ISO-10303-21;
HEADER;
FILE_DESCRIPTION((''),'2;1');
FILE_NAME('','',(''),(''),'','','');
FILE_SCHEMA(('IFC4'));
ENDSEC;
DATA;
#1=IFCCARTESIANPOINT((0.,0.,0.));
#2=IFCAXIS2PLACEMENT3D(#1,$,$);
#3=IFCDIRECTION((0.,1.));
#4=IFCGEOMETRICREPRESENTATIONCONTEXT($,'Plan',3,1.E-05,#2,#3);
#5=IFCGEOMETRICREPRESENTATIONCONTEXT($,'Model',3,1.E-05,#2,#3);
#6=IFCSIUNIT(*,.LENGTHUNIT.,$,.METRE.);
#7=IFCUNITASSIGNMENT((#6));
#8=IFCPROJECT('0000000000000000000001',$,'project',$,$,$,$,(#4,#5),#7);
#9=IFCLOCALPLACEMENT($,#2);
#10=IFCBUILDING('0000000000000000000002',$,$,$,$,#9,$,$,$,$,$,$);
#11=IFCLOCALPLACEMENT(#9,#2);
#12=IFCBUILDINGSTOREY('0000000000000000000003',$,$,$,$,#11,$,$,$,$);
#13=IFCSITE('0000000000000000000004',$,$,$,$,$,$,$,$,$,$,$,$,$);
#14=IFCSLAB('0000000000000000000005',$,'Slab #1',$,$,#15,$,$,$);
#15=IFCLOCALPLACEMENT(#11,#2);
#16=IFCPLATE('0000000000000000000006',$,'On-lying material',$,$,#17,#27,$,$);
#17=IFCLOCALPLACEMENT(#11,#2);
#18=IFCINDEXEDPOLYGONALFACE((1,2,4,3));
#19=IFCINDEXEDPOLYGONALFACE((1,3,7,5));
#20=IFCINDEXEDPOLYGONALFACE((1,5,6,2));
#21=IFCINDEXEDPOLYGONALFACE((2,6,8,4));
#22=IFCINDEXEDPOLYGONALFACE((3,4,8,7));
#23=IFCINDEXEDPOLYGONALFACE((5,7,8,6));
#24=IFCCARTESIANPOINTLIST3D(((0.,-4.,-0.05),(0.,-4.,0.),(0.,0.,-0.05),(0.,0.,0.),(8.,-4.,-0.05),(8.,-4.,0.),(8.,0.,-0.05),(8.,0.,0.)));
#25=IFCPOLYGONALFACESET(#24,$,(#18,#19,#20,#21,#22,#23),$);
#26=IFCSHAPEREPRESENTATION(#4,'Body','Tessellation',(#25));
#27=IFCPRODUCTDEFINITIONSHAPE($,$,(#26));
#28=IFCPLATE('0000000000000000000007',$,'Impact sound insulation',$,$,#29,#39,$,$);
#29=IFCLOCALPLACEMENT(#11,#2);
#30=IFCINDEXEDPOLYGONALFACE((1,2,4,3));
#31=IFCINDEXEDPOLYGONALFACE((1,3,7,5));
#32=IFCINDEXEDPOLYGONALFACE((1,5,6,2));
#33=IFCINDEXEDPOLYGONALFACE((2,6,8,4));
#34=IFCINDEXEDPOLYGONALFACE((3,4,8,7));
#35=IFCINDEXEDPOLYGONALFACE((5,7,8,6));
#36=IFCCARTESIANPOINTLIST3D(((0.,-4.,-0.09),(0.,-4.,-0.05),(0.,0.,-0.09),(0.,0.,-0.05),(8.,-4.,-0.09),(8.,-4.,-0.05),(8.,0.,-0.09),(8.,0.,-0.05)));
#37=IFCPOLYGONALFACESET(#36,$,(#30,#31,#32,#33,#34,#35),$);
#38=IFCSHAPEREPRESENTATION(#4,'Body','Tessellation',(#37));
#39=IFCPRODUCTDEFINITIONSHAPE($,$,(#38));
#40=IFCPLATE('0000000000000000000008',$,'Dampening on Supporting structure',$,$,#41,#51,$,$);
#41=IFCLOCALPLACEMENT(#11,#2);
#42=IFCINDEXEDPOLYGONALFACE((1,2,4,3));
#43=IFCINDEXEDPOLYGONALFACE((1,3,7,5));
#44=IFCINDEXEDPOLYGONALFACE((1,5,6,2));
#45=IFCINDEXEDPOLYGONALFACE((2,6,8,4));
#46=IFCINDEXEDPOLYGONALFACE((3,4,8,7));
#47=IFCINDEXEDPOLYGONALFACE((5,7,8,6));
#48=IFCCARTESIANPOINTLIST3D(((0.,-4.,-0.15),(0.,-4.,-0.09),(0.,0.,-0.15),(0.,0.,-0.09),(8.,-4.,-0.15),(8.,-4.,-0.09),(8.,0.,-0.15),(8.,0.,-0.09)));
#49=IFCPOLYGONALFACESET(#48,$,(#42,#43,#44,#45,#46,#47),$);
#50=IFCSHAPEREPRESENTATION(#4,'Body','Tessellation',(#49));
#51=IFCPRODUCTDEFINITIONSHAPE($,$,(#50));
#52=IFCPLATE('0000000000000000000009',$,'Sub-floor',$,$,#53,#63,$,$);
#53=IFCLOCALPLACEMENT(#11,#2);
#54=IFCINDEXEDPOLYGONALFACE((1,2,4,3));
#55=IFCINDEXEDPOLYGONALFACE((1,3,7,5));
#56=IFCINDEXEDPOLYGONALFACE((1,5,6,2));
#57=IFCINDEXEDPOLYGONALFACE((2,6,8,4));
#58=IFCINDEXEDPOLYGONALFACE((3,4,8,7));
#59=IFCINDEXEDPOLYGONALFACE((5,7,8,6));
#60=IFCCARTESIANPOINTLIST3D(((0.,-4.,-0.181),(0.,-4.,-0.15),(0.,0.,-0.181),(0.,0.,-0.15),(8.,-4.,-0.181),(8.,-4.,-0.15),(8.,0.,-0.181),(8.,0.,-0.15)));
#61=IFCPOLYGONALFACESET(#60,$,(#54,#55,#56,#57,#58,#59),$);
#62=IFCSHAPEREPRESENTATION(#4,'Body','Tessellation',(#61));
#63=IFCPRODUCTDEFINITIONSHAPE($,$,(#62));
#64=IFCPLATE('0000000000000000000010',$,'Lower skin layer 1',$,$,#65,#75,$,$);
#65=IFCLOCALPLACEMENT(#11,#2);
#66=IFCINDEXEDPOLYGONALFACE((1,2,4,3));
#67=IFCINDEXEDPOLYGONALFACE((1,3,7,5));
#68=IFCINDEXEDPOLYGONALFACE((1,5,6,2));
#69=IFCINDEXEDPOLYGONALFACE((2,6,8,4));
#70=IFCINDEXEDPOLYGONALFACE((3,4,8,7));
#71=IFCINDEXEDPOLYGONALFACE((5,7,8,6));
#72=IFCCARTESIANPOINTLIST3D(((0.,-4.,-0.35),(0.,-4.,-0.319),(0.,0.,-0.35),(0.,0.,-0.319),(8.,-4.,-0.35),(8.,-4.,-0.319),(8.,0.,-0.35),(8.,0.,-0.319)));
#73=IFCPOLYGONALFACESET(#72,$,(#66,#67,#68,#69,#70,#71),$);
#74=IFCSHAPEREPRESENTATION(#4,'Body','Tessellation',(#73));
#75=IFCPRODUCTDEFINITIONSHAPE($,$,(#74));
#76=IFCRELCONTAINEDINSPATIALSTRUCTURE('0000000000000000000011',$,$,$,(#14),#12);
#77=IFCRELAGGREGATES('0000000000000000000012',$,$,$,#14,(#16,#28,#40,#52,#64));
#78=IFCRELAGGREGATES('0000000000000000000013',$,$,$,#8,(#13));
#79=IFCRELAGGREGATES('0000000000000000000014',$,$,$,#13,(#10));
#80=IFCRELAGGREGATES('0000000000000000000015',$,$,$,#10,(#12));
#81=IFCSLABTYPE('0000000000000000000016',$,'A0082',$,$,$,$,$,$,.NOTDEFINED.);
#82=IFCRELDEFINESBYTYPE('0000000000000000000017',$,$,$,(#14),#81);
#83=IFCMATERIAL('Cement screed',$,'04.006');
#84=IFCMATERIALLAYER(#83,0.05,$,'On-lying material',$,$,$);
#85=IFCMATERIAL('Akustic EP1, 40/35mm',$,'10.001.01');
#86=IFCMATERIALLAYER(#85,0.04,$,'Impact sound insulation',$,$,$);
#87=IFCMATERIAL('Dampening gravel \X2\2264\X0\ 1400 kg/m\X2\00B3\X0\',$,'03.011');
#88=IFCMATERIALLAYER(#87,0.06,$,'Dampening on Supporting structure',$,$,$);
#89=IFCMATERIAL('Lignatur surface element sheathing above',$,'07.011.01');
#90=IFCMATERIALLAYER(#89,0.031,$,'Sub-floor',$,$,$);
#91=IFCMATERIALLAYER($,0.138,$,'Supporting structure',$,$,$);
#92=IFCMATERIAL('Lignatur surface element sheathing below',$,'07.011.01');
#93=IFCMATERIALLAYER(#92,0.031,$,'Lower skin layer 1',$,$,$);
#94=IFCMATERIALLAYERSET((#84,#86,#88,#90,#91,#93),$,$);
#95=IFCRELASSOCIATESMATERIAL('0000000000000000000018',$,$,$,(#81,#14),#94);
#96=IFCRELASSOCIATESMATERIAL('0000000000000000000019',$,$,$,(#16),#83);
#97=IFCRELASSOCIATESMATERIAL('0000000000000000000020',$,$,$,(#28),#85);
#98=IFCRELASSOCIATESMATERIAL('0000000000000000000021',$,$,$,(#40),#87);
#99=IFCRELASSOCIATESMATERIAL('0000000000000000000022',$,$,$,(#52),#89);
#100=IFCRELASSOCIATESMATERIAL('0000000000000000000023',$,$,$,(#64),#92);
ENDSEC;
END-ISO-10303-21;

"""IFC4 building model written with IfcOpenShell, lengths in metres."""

from ifc_helpers import new_model, si_unit, direction, frame, frame_2d, origin, origin_with_axes, place, context, project, spatial, rectangle, extrude, material, layer, layer_set, type_object, element, aggregate, save


model = new_model("IFC4")

# Units and contexts
plan_context = context("Plan", 3, precision=1e-05, world=origin(), true_north=direction((0.0, 1.0)))
model_context = context("Model", 3, precision=1e-05, world=origin(), true_north=direction((0.0, 1.0)))
ifc_project = project(units=[si_unit("LENGTHUNIT", "METRE")], contexts=[plan_context, model_context])

# Site, building, storey
site = spatial("IfcSite", under=ifc_project)
building_placement = place(None, origin())
building = spatial("IfcBuilding", under=site, at=building_placement)
storey_placement = place(building_placement, origin())
storey = spatial("IfcBuildingStorey", under=building, at=storey_placement)

# Slab, plates
ifc_material_1 = material(Name="Cement screed", Category="04.006")
ifc_layer_1 = layer(ifc_material_1, 0.05, Name="On-lying material")
ifc_material_2 = material(Name="Akustic EP1, 40/35mm", Category="10.001.01")
ifc_layer_2 = layer(ifc_material_2, 0.04, Name="Impact sound insulation")
ifc_material_3 = material(Name="Dampening gravel ≤ 1400 kg/m³", Category="03.011")
ifc_layer_3 = layer(ifc_material_3, 0.06, Name="Dampening on Supporting structure")
ifc_material_4 = material(Name="Lignatur surface element sheathing above", Category="07.011.01")
ifc_layer_4 = layer(ifc_material_4, 0.031, Name="Sub-floor")
ifc_layer_5 = layer(None, 0.138, Name="Supporting structure")
ifc_material_5 = material(Name="Lignatur surface element sheathing below", Category="07.011.01")
ifc_layer_6 = layer(ifc_material_5, 0.031, Name="Lower skin layer 1")
ifc_layer_set = layer_set([ifc_layer_1, ifc_layer_2, ifc_layer_3, ifc_layer_4, ifc_layer_5, ifc_layer_6])
slab_type = type_object("IfcSlabType", Name="A0082", PredefinedType="NOTDEFINED", material=ifc_layer_set)
slab_placement = place(None, frame((0.0, 0.0, 0.0), z_axis=(0.0, 0.0, -1.0), x_axis=(1.0, 0.0, 0.0)))
slab = element("IfcSlab", 1, at=slab_placement, inside=storey, type_object=slab_type, material=ifc_layer_set, Name="Slab #1")
plate_1_placement = place(slab_placement, origin())
plate_1 = element("IfcPlate", 2, at=plate_1_placement, material=ifc_material_1, Name="On-lying material", context=plan_context, shape_type="SweptSolid", body=[
    extrude(rectangle(XDim=8.0, YDim=4.0, at=frame_2d((4.0, 2.0), x_axis=(1.0, 0.0))), origin_with_axes(), (0.0, 0.0, 1.0), 0.05),
])
plate_2_placement = place(slab_placement, origin())
plate_2 = element("IfcPlate", 3, at=plate_2_placement, material=ifc_material_2, Name="Impact sound insulation", context=plan_context, shape_type="SweptSolid", body=[
    extrude(rectangle(XDim=8.0, YDim=4.0, at=frame_2d((4.0, 2.0), x_axis=(1.0, 0.0))), frame((0.0, 0.0, 0.05), z_axis=(0.0, 0.0, 1.0), x_axis=(1.0, 0.0, 0.0)), (0.0, 0.0, 1.0), 0.04),
])
plate_3_placement = place(slab_placement, origin())
plate_3 = element("IfcPlate", 4, at=plate_3_placement, material=ifc_material_3, Name="Dampening on Supporting structure", context=plan_context, shape_type="SweptSolid", body=[
    extrude(rectangle(XDim=8.0, YDim=4.0, at=frame_2d((4.0, 2.0), x_axis=(1.0, 0.0))), frame((0.0, 0.0, 0.09), z_axis=(0.0, 0.0, 1.0), x_axis=(1.0, 0.0, 0.0)), (0.0, 0.0, 1.0), 0.06),
])
plate_4_placement = place(slab_placement, origin())
plate_4 = element("IfcPlate", 5, at=plate_4_placement, material=ifc_material_4, Name="Sub-floor", context=plan_context, shape_type="SweptSolid", body=[
    extrude(rectangle(XDim=8.0, YDim=4.0, at=frame_2d((4.0, 2.0), x_axis=(1.0, 0.0))), frame((0.0, 0.0, 0.15), z_axis=(0.0, 0.0, 1.0), x_axis=(1.0, 0.0, 0.0)), (0.0, 0.0, 1.0), 0.031),
])
plate_5_placement = place(slab_placement, origin())
plate_5 = element("IfcPlate", 6, at=plate_5_placement, material=ifc_material_5, Name="Lower skin layer 1", context=plan_context, shape_type="SweptSolid", body=[
    extrude(rectangle(XDim=8.0, YDim=4.0, at=frame_2d((4.0, 2.0), x_axis=(1.0, 0.0))), frame((0.0, 0.0, 0.319), z_axis=(0.0, 0.0, 1.0), x_axis=(1.0, 0.0, 0.0)), (0.0, 0.0, 1.0), 0.031),
])
aggregate(slab, [plate_1, plate_2, plate_3, plate_4, plate_5])

save(model, "model.ifc")
